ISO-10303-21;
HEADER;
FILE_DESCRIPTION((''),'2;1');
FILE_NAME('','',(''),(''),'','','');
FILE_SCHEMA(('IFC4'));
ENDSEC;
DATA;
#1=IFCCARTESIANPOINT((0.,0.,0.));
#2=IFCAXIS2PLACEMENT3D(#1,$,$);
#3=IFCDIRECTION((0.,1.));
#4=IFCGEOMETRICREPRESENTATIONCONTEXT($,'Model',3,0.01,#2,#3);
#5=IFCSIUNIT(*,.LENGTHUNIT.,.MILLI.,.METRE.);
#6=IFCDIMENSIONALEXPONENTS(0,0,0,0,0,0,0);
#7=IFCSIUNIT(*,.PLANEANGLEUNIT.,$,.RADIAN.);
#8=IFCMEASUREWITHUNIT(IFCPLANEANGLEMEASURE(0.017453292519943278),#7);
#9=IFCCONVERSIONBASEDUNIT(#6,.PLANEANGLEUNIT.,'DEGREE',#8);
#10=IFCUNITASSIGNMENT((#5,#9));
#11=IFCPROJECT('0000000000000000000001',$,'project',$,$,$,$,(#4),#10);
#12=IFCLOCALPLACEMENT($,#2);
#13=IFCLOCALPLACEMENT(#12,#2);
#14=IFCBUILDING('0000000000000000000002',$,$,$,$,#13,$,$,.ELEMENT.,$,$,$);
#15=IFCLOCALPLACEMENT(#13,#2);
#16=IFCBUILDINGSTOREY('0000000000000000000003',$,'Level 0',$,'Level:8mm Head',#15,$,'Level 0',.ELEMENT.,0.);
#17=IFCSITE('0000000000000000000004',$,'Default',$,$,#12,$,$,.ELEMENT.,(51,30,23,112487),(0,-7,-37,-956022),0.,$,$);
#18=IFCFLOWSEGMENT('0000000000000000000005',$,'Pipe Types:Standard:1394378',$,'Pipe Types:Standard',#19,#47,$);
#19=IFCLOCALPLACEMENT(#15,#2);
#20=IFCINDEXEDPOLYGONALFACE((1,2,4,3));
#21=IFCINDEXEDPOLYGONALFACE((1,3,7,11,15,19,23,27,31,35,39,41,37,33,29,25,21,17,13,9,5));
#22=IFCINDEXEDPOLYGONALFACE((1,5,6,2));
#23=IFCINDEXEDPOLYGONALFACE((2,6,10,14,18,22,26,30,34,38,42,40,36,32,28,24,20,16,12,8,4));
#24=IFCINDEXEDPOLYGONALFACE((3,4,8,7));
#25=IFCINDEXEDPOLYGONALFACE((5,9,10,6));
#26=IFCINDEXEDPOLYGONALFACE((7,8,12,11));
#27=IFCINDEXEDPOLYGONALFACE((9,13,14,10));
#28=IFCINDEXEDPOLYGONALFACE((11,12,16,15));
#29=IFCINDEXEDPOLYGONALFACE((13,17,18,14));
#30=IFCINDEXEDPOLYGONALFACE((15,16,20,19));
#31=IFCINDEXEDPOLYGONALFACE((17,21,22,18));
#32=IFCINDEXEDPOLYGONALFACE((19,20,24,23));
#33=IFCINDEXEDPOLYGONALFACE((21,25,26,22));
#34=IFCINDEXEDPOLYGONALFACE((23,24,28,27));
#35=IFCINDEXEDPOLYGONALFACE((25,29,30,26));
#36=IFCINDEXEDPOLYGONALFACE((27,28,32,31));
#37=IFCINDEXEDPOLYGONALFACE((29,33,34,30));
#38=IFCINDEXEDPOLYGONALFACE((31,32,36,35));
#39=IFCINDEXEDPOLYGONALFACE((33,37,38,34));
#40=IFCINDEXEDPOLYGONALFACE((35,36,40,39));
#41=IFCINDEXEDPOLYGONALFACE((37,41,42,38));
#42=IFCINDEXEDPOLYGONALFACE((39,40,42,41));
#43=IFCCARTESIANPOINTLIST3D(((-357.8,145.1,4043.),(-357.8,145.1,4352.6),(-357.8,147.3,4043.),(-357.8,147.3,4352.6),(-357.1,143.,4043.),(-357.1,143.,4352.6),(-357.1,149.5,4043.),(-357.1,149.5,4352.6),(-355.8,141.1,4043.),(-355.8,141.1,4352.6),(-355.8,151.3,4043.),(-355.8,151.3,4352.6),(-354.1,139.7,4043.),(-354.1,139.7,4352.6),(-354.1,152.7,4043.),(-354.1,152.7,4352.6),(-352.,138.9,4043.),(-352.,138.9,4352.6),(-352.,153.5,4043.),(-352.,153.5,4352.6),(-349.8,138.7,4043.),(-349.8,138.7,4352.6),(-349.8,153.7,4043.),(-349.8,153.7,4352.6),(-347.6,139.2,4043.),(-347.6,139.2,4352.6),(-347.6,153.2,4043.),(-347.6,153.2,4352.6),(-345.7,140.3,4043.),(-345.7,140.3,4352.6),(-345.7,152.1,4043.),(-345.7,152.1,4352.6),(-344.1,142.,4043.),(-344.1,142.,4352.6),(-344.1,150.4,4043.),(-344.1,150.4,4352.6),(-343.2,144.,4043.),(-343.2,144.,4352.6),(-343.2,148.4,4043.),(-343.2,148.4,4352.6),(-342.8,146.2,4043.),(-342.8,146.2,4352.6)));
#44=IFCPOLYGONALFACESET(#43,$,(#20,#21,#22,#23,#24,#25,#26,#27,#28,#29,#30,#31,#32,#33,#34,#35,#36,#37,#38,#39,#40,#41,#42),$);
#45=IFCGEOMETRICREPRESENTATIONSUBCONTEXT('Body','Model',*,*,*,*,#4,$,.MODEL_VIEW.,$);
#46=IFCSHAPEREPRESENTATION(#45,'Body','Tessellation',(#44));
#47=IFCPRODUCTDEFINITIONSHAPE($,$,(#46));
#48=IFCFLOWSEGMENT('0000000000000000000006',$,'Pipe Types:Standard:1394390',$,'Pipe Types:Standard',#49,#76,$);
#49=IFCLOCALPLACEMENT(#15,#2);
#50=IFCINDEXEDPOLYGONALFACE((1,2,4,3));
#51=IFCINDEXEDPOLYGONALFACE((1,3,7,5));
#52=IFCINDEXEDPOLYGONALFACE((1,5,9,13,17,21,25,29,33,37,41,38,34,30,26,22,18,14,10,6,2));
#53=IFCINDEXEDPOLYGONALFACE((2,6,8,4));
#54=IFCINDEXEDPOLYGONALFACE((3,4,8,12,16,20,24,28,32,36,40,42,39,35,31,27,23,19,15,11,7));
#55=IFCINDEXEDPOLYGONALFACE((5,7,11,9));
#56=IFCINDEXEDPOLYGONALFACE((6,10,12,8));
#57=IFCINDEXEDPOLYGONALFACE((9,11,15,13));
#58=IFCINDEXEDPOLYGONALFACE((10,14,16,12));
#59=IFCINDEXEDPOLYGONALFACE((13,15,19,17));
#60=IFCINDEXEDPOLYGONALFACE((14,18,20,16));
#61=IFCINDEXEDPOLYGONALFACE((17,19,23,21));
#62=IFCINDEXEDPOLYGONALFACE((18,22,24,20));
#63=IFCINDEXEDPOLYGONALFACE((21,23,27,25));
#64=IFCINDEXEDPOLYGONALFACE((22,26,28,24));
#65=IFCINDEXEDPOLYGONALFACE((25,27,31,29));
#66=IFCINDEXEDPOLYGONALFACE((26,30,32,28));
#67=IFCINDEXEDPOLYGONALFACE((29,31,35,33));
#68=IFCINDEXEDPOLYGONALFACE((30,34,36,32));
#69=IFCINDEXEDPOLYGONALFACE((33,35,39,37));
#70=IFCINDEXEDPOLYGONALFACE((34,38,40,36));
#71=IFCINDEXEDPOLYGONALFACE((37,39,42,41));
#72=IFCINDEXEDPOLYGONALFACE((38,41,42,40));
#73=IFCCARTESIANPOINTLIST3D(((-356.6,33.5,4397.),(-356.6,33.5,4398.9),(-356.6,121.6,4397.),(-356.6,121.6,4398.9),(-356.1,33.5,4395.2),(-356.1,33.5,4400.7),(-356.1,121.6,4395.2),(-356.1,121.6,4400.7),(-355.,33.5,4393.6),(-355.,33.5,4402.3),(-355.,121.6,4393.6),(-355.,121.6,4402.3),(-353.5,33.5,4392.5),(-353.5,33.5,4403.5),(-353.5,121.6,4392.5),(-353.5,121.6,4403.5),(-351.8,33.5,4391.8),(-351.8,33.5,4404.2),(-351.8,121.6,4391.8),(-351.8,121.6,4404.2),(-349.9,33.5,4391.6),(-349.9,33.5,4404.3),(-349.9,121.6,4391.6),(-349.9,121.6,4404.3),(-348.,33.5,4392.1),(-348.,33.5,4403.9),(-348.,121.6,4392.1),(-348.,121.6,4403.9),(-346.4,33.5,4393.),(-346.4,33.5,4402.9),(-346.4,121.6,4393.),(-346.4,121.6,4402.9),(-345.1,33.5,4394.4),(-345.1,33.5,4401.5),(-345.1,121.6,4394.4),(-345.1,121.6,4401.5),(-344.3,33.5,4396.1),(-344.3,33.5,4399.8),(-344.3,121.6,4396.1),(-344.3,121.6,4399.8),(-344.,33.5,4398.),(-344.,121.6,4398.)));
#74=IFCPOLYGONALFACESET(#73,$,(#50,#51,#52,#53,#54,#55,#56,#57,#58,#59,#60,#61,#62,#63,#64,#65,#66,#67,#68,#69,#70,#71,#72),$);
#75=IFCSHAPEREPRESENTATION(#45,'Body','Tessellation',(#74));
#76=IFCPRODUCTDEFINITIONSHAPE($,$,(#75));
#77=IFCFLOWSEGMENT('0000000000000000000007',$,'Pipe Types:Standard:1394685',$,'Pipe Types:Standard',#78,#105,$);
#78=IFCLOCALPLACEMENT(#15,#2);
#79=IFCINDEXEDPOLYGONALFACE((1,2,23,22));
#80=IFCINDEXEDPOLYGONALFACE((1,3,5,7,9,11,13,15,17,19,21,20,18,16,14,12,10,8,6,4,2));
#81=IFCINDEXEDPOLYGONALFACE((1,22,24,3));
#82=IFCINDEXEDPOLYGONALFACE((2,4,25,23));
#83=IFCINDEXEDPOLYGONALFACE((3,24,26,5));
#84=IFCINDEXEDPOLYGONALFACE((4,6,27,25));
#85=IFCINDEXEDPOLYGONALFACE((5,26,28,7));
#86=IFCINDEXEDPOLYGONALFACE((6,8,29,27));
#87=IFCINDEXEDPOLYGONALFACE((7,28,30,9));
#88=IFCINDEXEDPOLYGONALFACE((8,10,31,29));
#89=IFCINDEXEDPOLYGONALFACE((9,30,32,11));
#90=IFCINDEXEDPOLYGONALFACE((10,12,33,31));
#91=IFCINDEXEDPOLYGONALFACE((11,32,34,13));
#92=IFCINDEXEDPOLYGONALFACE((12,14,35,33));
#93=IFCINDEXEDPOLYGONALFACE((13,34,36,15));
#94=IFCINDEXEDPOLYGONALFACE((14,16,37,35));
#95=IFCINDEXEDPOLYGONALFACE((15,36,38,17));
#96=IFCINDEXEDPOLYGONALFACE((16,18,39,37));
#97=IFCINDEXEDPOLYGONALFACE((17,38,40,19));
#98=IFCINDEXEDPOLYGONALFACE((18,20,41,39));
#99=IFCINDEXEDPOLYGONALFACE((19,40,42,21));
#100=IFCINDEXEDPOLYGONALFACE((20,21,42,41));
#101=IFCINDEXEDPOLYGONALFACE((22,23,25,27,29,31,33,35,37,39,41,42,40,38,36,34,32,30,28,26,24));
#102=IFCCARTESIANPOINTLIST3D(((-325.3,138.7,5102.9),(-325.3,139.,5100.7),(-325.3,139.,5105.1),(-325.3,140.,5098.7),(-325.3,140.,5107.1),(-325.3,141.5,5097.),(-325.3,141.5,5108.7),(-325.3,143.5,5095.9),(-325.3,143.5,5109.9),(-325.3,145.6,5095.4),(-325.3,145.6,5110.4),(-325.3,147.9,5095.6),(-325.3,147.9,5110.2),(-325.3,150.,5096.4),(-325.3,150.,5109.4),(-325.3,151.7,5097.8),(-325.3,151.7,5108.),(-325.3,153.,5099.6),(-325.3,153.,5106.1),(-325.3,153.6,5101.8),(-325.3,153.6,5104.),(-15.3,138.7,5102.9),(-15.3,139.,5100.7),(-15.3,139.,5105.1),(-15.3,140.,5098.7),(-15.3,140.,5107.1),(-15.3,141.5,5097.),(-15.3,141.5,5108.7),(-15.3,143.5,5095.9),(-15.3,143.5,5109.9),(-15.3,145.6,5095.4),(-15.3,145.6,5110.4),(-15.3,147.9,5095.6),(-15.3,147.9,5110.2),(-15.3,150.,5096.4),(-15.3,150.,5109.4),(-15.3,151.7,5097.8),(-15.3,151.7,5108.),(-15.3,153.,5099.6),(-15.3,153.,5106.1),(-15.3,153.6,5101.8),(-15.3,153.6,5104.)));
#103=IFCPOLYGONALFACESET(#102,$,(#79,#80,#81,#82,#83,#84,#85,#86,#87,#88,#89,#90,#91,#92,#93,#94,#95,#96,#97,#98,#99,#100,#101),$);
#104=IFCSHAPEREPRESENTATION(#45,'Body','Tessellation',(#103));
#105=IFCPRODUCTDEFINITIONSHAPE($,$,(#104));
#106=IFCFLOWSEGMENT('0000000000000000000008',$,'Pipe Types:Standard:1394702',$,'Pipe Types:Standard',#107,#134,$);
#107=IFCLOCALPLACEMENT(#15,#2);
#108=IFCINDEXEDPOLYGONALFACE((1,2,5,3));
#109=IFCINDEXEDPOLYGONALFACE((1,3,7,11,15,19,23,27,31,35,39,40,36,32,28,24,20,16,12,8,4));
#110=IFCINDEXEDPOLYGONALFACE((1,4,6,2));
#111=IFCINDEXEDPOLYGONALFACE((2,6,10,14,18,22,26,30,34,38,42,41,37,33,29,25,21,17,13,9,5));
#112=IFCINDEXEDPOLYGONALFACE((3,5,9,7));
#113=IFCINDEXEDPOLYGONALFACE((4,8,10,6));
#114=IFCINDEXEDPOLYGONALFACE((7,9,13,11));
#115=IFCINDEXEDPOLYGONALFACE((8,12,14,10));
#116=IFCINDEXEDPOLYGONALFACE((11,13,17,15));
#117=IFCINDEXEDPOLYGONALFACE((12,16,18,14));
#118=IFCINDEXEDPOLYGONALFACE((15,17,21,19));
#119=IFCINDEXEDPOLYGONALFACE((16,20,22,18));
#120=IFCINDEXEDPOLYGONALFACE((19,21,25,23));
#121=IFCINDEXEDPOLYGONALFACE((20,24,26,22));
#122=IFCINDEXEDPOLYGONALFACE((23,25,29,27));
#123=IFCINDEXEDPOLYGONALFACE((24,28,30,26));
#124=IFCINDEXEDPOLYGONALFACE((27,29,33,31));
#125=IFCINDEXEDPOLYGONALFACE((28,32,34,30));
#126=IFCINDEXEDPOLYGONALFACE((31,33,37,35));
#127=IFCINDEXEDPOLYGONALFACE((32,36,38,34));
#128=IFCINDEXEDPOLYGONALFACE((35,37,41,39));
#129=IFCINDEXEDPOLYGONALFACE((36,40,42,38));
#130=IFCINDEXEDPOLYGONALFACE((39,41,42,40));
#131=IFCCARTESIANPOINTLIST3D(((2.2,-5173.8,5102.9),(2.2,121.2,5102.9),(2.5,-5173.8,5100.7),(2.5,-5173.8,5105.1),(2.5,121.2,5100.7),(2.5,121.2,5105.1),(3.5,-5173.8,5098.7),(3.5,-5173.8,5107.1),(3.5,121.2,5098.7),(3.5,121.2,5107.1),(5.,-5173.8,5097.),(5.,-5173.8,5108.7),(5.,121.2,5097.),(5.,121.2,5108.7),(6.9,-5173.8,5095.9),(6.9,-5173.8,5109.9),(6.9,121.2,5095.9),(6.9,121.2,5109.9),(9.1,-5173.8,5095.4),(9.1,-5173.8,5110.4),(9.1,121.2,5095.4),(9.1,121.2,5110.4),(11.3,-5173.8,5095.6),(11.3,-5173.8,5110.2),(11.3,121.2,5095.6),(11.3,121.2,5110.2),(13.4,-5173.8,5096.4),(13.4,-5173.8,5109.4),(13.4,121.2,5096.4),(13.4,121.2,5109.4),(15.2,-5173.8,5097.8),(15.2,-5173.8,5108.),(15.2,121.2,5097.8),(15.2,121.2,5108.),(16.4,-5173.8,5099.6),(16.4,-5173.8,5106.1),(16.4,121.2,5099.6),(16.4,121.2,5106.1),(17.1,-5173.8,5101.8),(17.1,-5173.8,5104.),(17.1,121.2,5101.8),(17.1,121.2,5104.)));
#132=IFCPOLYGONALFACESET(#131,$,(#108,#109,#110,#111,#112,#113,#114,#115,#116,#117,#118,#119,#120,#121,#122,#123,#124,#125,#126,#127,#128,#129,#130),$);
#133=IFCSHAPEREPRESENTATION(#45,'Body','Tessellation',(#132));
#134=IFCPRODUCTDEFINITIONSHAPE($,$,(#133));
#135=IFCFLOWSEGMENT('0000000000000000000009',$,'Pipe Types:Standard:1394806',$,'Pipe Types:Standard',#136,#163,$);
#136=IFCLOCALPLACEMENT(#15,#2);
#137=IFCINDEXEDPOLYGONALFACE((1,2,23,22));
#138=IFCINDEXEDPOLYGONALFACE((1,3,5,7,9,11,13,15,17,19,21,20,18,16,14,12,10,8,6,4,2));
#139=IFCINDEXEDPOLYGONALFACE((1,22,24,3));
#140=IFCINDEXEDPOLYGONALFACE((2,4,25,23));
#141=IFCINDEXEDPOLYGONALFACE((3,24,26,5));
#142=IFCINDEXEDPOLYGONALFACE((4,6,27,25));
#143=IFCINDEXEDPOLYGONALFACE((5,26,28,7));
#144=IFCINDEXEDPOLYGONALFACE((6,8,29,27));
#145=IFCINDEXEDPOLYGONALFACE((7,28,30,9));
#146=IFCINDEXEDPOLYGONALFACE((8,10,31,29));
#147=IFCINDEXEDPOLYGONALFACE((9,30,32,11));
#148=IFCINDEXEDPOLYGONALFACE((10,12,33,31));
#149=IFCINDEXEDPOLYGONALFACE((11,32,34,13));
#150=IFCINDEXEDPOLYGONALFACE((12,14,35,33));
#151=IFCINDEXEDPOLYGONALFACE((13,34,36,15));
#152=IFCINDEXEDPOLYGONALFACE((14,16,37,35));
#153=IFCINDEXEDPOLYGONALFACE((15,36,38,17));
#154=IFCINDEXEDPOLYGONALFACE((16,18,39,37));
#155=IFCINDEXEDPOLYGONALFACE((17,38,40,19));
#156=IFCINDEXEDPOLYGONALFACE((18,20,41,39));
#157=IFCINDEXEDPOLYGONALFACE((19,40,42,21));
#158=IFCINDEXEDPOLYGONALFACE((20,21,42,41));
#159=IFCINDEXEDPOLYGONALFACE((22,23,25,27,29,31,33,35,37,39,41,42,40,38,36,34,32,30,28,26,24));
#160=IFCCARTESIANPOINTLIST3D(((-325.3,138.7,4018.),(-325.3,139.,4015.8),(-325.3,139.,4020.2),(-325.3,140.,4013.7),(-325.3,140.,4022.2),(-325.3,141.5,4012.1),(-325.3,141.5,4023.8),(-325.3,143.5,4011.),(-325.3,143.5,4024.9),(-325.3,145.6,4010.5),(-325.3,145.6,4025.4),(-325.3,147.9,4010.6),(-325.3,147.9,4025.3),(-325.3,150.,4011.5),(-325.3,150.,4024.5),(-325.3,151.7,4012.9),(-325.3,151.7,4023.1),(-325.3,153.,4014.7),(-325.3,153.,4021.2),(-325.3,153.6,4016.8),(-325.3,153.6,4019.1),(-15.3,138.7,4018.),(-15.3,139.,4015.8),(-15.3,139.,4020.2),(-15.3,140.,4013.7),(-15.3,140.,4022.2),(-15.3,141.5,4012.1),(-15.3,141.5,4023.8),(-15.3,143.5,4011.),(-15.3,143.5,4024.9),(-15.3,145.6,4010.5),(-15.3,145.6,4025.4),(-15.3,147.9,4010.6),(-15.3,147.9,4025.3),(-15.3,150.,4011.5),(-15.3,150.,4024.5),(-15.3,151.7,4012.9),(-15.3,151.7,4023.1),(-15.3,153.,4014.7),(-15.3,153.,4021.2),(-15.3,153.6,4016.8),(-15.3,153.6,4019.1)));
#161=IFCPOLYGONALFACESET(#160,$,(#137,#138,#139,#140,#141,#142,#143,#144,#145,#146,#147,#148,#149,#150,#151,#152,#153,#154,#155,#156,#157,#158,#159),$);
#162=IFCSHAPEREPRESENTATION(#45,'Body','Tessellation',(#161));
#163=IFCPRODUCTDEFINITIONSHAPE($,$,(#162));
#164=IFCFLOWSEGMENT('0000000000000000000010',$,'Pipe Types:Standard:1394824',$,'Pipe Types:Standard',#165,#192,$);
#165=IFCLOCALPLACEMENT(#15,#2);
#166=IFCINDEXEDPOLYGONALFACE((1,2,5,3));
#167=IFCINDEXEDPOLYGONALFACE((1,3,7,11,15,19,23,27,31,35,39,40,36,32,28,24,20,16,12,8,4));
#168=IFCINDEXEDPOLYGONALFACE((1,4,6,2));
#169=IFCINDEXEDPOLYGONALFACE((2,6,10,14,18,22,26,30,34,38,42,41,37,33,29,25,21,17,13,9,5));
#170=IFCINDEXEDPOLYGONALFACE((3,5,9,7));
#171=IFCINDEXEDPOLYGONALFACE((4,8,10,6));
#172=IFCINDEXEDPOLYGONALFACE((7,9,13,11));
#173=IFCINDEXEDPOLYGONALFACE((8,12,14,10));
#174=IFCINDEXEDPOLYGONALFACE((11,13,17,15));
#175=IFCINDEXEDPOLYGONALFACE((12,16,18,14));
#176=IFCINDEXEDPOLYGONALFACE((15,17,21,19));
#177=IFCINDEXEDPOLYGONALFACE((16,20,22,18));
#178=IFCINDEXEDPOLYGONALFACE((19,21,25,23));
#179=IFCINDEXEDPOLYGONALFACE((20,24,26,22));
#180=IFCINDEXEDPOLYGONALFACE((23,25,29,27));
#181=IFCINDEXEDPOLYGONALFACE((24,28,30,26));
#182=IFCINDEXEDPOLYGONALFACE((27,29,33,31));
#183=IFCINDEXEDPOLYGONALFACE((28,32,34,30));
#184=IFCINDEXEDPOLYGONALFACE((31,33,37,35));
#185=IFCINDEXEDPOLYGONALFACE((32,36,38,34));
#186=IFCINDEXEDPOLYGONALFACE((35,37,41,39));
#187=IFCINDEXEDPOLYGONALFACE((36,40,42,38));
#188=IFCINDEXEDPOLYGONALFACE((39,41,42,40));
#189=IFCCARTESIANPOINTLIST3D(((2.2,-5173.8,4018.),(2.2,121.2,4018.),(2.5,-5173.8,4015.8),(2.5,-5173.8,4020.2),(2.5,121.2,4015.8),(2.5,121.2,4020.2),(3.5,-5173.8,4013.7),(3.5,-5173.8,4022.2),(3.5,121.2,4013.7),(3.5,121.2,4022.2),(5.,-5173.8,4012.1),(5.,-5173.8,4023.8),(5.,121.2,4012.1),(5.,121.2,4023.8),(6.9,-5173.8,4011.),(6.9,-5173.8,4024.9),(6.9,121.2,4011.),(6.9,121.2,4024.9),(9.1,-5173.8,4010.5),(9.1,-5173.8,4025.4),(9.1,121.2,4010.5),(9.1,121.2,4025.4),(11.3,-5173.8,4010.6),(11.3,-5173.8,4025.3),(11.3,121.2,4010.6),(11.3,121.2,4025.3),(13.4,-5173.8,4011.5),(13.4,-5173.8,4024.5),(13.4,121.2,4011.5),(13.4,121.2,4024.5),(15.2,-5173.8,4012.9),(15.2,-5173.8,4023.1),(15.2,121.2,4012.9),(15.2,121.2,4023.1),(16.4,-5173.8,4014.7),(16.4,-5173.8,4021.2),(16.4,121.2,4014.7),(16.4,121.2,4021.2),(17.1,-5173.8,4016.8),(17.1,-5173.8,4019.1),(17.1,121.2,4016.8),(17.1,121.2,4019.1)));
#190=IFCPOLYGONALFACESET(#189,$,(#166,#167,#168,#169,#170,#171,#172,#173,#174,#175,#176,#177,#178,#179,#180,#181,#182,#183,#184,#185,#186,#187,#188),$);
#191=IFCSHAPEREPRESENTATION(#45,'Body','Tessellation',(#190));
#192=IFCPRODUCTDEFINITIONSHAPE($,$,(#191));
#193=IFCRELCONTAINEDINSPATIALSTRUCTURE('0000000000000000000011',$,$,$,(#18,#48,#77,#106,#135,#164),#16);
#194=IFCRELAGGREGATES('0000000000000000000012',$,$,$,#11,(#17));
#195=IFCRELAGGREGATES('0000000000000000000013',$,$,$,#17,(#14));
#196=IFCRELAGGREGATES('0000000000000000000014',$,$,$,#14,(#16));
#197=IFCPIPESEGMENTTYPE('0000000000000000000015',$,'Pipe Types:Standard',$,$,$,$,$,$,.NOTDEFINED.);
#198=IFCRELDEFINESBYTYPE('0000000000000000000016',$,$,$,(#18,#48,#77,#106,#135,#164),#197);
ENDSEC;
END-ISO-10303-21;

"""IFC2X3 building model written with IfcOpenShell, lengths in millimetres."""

from ifc_helpers import new_model, entity, si_unit, converted_unit, direction, frame, frame_2d, origin, origin_2d_with_axis, place, context, subcontext, project, spatial, circle, extrude, type_object, element, save


model = new_model("IFC2X3")

# Units and contexts
model_context = context("Model", 3, precision=0.01, world=origin(), true_north=direction((0.0, 1.0)))
body_context = subcontext(model_context, "Body", "Model", "MODEL_VIEW")
ifc_project = project(units=[si_unit("LENGTHUNIT", "METRE", prefix="MILLI"), converted_unit("PLANEANGLEUNIT", "DEGREE", entity("IfcPlaneAngleMeasure", 0.017453292519943278), si_unit("PLANEANGLEUNIT", "RADIAN"), dimensions=[0, 0, 0, 0, 0, 0, 0])], contexts=[model_context])

# Site, building, storey
site_placement = place(None, origin())
site = spatial("IfcSite", under=ifc_project, at=site_placement, Name="Default", CompositionType="ELEMENT", RefLatitude=(51, 30, 23, 112487), RefLongitude=(0, -7, -37, -956022), RefElevation=0.0)
building_placement = place(site_placement, origin())
building = spatial("IfcBuilding", under=site, at=building_placement, CompositionType="ELEMENT")
storey_placement = place(building_placement, origin())
storey = spatial("IfcBuildingStorey", under=building, at=storey_placement, Name="Level 0", ObjectType="Level:8mm Head", LongName="Level 0", CompositionType="ELEMENT", Elevation=0.0)

# Flow segments
pipe_segment_type = type_object("IfcPipeSegmentType", Name="Pipe Types:Standard", PredefinedType="NOTDEFINED")
flow_segment_1_placement = place(storey_placement, origin())
element("IfcFlowSegment", 1, at=flow_segment_1_placement, inside=storey, type_object=pipe_segment_type, Name="Pipe Types:Standard:1394378", ObjectType="Pipe Types:Standard", context=body_context, shape_type="SweptSolid", body=[
    extrude(circle(Radius=7.5, at=origin_2d_with_axis()), frame((-350.3, 146.2, 4043.0)), (0.0, 0.0, 1.0), 309.6),
])
flow_segment_2_placement = place(storey_placement, origin())
element("IfcFlowSegment", 2, at=flow_segment_2_placement, inside=storey, type_object=pipe_segment_type, Name="Pipe Types:Standard:1394390", ObjectType="Pipe Types:Standard", context=body_context, shape_type="SweptSolid", body=[
    extrude(circle(Radius=6.4, at=origin_2d_with_axis()), frame((-350.3, 33.5, 4398.0), z_axis=(0.0, 1.0, 0.0), x_axis=(1.0, 0.0, 0.0)), (0.0, 0.0, 1.0), 88.1),
])
flow_segment_3_placement = place(storey_placement, origin())
element("IfcFlowSegment", 3, at=flow_segment_3_placement, inside=storey, type_object=pipe_segment_type, Name="Pipe Types:Standard:1394685", ObjectType="Pipe Types:Standard", context=body_context, shape_type="SweptSolid", body=[
    extrude(circle(Radius=7.5, at=origin_2d_with_axis()), frame((-325.3, 146.2, 5102.9), z_axis=(1.0, 0.0, 0.0), x_axis=(0.0, -1.0, 0.0)), (0.0, 0.0, 1.0), 310.0),
])
flow_segment_4_placement = place(storey_placement, origin())
element("IfcFlowSegment", 4, at=flow_segment_4_placement, inside=storey, type_object=pipe_segment_type, Name="Pipe Types:Standard:1394702", ObjectType="Pipe Types:Standard", context=body_context, shape_type="SweptSolid", body=[
    extrude(circle(Radius=7.5, at=frame_2d((0.0, 0.0), x_axis=(1.0, 0.0))), frame((9.7, -5173.8, 5102.9), z_axis=(0.0, 1.0, 0.0), x_axis=(-1.0, 0.0, 0.0)), (0.0, 0.0, 1.0), 5295.0),
])
flow_segment_5_placement = place(storey_placement, origin())
element("IfcFlowSegment", 5, at=flow_segment_5_placement, inside=storey, type_object=pipe_segment_type, Name="Pipe Types:Standard:1394806", ObjectType="Pipe Types:Standard", context=body_context, shape_type="SweptSolid", body=[
    extrude(circle(Radius=7.5, at=frame_2d((0.0, 0.0), x_axis=(1.0, 0.0))), frame((-325.3, 146.2, 4018.0), z_axis=(1.0, 0.0, 0.0), x_axis=(0.0, -1.0, 0.0)), (0.0, 0.0, 1.0), 310.0),
])
flow_segment_6_placement = place(storey_placement, origin())
element("IfcFlowSegment", 6, at=flow_segment_6_placement, inside=storey, type_object=pipe_segment_type, Name="Pipe Types:Standard:1394824", ObjectType="Pipe Types:Standard", context=body_context, shape_type="SweptSolid", body=[
    extrude(circle(Radius=7.5, at=frame_2d((0.0, 0.0), x_axis=(1.0, 0.0))), frame((9.7, -5173.8, 4018.0), z_axis=(0.0, 1.0, 0.0), x_axis=(-1.0, 0.0, 0.0)), (0.0, 0.0, 1.0), 5295.0),
])

save(model, "model.ifc")
